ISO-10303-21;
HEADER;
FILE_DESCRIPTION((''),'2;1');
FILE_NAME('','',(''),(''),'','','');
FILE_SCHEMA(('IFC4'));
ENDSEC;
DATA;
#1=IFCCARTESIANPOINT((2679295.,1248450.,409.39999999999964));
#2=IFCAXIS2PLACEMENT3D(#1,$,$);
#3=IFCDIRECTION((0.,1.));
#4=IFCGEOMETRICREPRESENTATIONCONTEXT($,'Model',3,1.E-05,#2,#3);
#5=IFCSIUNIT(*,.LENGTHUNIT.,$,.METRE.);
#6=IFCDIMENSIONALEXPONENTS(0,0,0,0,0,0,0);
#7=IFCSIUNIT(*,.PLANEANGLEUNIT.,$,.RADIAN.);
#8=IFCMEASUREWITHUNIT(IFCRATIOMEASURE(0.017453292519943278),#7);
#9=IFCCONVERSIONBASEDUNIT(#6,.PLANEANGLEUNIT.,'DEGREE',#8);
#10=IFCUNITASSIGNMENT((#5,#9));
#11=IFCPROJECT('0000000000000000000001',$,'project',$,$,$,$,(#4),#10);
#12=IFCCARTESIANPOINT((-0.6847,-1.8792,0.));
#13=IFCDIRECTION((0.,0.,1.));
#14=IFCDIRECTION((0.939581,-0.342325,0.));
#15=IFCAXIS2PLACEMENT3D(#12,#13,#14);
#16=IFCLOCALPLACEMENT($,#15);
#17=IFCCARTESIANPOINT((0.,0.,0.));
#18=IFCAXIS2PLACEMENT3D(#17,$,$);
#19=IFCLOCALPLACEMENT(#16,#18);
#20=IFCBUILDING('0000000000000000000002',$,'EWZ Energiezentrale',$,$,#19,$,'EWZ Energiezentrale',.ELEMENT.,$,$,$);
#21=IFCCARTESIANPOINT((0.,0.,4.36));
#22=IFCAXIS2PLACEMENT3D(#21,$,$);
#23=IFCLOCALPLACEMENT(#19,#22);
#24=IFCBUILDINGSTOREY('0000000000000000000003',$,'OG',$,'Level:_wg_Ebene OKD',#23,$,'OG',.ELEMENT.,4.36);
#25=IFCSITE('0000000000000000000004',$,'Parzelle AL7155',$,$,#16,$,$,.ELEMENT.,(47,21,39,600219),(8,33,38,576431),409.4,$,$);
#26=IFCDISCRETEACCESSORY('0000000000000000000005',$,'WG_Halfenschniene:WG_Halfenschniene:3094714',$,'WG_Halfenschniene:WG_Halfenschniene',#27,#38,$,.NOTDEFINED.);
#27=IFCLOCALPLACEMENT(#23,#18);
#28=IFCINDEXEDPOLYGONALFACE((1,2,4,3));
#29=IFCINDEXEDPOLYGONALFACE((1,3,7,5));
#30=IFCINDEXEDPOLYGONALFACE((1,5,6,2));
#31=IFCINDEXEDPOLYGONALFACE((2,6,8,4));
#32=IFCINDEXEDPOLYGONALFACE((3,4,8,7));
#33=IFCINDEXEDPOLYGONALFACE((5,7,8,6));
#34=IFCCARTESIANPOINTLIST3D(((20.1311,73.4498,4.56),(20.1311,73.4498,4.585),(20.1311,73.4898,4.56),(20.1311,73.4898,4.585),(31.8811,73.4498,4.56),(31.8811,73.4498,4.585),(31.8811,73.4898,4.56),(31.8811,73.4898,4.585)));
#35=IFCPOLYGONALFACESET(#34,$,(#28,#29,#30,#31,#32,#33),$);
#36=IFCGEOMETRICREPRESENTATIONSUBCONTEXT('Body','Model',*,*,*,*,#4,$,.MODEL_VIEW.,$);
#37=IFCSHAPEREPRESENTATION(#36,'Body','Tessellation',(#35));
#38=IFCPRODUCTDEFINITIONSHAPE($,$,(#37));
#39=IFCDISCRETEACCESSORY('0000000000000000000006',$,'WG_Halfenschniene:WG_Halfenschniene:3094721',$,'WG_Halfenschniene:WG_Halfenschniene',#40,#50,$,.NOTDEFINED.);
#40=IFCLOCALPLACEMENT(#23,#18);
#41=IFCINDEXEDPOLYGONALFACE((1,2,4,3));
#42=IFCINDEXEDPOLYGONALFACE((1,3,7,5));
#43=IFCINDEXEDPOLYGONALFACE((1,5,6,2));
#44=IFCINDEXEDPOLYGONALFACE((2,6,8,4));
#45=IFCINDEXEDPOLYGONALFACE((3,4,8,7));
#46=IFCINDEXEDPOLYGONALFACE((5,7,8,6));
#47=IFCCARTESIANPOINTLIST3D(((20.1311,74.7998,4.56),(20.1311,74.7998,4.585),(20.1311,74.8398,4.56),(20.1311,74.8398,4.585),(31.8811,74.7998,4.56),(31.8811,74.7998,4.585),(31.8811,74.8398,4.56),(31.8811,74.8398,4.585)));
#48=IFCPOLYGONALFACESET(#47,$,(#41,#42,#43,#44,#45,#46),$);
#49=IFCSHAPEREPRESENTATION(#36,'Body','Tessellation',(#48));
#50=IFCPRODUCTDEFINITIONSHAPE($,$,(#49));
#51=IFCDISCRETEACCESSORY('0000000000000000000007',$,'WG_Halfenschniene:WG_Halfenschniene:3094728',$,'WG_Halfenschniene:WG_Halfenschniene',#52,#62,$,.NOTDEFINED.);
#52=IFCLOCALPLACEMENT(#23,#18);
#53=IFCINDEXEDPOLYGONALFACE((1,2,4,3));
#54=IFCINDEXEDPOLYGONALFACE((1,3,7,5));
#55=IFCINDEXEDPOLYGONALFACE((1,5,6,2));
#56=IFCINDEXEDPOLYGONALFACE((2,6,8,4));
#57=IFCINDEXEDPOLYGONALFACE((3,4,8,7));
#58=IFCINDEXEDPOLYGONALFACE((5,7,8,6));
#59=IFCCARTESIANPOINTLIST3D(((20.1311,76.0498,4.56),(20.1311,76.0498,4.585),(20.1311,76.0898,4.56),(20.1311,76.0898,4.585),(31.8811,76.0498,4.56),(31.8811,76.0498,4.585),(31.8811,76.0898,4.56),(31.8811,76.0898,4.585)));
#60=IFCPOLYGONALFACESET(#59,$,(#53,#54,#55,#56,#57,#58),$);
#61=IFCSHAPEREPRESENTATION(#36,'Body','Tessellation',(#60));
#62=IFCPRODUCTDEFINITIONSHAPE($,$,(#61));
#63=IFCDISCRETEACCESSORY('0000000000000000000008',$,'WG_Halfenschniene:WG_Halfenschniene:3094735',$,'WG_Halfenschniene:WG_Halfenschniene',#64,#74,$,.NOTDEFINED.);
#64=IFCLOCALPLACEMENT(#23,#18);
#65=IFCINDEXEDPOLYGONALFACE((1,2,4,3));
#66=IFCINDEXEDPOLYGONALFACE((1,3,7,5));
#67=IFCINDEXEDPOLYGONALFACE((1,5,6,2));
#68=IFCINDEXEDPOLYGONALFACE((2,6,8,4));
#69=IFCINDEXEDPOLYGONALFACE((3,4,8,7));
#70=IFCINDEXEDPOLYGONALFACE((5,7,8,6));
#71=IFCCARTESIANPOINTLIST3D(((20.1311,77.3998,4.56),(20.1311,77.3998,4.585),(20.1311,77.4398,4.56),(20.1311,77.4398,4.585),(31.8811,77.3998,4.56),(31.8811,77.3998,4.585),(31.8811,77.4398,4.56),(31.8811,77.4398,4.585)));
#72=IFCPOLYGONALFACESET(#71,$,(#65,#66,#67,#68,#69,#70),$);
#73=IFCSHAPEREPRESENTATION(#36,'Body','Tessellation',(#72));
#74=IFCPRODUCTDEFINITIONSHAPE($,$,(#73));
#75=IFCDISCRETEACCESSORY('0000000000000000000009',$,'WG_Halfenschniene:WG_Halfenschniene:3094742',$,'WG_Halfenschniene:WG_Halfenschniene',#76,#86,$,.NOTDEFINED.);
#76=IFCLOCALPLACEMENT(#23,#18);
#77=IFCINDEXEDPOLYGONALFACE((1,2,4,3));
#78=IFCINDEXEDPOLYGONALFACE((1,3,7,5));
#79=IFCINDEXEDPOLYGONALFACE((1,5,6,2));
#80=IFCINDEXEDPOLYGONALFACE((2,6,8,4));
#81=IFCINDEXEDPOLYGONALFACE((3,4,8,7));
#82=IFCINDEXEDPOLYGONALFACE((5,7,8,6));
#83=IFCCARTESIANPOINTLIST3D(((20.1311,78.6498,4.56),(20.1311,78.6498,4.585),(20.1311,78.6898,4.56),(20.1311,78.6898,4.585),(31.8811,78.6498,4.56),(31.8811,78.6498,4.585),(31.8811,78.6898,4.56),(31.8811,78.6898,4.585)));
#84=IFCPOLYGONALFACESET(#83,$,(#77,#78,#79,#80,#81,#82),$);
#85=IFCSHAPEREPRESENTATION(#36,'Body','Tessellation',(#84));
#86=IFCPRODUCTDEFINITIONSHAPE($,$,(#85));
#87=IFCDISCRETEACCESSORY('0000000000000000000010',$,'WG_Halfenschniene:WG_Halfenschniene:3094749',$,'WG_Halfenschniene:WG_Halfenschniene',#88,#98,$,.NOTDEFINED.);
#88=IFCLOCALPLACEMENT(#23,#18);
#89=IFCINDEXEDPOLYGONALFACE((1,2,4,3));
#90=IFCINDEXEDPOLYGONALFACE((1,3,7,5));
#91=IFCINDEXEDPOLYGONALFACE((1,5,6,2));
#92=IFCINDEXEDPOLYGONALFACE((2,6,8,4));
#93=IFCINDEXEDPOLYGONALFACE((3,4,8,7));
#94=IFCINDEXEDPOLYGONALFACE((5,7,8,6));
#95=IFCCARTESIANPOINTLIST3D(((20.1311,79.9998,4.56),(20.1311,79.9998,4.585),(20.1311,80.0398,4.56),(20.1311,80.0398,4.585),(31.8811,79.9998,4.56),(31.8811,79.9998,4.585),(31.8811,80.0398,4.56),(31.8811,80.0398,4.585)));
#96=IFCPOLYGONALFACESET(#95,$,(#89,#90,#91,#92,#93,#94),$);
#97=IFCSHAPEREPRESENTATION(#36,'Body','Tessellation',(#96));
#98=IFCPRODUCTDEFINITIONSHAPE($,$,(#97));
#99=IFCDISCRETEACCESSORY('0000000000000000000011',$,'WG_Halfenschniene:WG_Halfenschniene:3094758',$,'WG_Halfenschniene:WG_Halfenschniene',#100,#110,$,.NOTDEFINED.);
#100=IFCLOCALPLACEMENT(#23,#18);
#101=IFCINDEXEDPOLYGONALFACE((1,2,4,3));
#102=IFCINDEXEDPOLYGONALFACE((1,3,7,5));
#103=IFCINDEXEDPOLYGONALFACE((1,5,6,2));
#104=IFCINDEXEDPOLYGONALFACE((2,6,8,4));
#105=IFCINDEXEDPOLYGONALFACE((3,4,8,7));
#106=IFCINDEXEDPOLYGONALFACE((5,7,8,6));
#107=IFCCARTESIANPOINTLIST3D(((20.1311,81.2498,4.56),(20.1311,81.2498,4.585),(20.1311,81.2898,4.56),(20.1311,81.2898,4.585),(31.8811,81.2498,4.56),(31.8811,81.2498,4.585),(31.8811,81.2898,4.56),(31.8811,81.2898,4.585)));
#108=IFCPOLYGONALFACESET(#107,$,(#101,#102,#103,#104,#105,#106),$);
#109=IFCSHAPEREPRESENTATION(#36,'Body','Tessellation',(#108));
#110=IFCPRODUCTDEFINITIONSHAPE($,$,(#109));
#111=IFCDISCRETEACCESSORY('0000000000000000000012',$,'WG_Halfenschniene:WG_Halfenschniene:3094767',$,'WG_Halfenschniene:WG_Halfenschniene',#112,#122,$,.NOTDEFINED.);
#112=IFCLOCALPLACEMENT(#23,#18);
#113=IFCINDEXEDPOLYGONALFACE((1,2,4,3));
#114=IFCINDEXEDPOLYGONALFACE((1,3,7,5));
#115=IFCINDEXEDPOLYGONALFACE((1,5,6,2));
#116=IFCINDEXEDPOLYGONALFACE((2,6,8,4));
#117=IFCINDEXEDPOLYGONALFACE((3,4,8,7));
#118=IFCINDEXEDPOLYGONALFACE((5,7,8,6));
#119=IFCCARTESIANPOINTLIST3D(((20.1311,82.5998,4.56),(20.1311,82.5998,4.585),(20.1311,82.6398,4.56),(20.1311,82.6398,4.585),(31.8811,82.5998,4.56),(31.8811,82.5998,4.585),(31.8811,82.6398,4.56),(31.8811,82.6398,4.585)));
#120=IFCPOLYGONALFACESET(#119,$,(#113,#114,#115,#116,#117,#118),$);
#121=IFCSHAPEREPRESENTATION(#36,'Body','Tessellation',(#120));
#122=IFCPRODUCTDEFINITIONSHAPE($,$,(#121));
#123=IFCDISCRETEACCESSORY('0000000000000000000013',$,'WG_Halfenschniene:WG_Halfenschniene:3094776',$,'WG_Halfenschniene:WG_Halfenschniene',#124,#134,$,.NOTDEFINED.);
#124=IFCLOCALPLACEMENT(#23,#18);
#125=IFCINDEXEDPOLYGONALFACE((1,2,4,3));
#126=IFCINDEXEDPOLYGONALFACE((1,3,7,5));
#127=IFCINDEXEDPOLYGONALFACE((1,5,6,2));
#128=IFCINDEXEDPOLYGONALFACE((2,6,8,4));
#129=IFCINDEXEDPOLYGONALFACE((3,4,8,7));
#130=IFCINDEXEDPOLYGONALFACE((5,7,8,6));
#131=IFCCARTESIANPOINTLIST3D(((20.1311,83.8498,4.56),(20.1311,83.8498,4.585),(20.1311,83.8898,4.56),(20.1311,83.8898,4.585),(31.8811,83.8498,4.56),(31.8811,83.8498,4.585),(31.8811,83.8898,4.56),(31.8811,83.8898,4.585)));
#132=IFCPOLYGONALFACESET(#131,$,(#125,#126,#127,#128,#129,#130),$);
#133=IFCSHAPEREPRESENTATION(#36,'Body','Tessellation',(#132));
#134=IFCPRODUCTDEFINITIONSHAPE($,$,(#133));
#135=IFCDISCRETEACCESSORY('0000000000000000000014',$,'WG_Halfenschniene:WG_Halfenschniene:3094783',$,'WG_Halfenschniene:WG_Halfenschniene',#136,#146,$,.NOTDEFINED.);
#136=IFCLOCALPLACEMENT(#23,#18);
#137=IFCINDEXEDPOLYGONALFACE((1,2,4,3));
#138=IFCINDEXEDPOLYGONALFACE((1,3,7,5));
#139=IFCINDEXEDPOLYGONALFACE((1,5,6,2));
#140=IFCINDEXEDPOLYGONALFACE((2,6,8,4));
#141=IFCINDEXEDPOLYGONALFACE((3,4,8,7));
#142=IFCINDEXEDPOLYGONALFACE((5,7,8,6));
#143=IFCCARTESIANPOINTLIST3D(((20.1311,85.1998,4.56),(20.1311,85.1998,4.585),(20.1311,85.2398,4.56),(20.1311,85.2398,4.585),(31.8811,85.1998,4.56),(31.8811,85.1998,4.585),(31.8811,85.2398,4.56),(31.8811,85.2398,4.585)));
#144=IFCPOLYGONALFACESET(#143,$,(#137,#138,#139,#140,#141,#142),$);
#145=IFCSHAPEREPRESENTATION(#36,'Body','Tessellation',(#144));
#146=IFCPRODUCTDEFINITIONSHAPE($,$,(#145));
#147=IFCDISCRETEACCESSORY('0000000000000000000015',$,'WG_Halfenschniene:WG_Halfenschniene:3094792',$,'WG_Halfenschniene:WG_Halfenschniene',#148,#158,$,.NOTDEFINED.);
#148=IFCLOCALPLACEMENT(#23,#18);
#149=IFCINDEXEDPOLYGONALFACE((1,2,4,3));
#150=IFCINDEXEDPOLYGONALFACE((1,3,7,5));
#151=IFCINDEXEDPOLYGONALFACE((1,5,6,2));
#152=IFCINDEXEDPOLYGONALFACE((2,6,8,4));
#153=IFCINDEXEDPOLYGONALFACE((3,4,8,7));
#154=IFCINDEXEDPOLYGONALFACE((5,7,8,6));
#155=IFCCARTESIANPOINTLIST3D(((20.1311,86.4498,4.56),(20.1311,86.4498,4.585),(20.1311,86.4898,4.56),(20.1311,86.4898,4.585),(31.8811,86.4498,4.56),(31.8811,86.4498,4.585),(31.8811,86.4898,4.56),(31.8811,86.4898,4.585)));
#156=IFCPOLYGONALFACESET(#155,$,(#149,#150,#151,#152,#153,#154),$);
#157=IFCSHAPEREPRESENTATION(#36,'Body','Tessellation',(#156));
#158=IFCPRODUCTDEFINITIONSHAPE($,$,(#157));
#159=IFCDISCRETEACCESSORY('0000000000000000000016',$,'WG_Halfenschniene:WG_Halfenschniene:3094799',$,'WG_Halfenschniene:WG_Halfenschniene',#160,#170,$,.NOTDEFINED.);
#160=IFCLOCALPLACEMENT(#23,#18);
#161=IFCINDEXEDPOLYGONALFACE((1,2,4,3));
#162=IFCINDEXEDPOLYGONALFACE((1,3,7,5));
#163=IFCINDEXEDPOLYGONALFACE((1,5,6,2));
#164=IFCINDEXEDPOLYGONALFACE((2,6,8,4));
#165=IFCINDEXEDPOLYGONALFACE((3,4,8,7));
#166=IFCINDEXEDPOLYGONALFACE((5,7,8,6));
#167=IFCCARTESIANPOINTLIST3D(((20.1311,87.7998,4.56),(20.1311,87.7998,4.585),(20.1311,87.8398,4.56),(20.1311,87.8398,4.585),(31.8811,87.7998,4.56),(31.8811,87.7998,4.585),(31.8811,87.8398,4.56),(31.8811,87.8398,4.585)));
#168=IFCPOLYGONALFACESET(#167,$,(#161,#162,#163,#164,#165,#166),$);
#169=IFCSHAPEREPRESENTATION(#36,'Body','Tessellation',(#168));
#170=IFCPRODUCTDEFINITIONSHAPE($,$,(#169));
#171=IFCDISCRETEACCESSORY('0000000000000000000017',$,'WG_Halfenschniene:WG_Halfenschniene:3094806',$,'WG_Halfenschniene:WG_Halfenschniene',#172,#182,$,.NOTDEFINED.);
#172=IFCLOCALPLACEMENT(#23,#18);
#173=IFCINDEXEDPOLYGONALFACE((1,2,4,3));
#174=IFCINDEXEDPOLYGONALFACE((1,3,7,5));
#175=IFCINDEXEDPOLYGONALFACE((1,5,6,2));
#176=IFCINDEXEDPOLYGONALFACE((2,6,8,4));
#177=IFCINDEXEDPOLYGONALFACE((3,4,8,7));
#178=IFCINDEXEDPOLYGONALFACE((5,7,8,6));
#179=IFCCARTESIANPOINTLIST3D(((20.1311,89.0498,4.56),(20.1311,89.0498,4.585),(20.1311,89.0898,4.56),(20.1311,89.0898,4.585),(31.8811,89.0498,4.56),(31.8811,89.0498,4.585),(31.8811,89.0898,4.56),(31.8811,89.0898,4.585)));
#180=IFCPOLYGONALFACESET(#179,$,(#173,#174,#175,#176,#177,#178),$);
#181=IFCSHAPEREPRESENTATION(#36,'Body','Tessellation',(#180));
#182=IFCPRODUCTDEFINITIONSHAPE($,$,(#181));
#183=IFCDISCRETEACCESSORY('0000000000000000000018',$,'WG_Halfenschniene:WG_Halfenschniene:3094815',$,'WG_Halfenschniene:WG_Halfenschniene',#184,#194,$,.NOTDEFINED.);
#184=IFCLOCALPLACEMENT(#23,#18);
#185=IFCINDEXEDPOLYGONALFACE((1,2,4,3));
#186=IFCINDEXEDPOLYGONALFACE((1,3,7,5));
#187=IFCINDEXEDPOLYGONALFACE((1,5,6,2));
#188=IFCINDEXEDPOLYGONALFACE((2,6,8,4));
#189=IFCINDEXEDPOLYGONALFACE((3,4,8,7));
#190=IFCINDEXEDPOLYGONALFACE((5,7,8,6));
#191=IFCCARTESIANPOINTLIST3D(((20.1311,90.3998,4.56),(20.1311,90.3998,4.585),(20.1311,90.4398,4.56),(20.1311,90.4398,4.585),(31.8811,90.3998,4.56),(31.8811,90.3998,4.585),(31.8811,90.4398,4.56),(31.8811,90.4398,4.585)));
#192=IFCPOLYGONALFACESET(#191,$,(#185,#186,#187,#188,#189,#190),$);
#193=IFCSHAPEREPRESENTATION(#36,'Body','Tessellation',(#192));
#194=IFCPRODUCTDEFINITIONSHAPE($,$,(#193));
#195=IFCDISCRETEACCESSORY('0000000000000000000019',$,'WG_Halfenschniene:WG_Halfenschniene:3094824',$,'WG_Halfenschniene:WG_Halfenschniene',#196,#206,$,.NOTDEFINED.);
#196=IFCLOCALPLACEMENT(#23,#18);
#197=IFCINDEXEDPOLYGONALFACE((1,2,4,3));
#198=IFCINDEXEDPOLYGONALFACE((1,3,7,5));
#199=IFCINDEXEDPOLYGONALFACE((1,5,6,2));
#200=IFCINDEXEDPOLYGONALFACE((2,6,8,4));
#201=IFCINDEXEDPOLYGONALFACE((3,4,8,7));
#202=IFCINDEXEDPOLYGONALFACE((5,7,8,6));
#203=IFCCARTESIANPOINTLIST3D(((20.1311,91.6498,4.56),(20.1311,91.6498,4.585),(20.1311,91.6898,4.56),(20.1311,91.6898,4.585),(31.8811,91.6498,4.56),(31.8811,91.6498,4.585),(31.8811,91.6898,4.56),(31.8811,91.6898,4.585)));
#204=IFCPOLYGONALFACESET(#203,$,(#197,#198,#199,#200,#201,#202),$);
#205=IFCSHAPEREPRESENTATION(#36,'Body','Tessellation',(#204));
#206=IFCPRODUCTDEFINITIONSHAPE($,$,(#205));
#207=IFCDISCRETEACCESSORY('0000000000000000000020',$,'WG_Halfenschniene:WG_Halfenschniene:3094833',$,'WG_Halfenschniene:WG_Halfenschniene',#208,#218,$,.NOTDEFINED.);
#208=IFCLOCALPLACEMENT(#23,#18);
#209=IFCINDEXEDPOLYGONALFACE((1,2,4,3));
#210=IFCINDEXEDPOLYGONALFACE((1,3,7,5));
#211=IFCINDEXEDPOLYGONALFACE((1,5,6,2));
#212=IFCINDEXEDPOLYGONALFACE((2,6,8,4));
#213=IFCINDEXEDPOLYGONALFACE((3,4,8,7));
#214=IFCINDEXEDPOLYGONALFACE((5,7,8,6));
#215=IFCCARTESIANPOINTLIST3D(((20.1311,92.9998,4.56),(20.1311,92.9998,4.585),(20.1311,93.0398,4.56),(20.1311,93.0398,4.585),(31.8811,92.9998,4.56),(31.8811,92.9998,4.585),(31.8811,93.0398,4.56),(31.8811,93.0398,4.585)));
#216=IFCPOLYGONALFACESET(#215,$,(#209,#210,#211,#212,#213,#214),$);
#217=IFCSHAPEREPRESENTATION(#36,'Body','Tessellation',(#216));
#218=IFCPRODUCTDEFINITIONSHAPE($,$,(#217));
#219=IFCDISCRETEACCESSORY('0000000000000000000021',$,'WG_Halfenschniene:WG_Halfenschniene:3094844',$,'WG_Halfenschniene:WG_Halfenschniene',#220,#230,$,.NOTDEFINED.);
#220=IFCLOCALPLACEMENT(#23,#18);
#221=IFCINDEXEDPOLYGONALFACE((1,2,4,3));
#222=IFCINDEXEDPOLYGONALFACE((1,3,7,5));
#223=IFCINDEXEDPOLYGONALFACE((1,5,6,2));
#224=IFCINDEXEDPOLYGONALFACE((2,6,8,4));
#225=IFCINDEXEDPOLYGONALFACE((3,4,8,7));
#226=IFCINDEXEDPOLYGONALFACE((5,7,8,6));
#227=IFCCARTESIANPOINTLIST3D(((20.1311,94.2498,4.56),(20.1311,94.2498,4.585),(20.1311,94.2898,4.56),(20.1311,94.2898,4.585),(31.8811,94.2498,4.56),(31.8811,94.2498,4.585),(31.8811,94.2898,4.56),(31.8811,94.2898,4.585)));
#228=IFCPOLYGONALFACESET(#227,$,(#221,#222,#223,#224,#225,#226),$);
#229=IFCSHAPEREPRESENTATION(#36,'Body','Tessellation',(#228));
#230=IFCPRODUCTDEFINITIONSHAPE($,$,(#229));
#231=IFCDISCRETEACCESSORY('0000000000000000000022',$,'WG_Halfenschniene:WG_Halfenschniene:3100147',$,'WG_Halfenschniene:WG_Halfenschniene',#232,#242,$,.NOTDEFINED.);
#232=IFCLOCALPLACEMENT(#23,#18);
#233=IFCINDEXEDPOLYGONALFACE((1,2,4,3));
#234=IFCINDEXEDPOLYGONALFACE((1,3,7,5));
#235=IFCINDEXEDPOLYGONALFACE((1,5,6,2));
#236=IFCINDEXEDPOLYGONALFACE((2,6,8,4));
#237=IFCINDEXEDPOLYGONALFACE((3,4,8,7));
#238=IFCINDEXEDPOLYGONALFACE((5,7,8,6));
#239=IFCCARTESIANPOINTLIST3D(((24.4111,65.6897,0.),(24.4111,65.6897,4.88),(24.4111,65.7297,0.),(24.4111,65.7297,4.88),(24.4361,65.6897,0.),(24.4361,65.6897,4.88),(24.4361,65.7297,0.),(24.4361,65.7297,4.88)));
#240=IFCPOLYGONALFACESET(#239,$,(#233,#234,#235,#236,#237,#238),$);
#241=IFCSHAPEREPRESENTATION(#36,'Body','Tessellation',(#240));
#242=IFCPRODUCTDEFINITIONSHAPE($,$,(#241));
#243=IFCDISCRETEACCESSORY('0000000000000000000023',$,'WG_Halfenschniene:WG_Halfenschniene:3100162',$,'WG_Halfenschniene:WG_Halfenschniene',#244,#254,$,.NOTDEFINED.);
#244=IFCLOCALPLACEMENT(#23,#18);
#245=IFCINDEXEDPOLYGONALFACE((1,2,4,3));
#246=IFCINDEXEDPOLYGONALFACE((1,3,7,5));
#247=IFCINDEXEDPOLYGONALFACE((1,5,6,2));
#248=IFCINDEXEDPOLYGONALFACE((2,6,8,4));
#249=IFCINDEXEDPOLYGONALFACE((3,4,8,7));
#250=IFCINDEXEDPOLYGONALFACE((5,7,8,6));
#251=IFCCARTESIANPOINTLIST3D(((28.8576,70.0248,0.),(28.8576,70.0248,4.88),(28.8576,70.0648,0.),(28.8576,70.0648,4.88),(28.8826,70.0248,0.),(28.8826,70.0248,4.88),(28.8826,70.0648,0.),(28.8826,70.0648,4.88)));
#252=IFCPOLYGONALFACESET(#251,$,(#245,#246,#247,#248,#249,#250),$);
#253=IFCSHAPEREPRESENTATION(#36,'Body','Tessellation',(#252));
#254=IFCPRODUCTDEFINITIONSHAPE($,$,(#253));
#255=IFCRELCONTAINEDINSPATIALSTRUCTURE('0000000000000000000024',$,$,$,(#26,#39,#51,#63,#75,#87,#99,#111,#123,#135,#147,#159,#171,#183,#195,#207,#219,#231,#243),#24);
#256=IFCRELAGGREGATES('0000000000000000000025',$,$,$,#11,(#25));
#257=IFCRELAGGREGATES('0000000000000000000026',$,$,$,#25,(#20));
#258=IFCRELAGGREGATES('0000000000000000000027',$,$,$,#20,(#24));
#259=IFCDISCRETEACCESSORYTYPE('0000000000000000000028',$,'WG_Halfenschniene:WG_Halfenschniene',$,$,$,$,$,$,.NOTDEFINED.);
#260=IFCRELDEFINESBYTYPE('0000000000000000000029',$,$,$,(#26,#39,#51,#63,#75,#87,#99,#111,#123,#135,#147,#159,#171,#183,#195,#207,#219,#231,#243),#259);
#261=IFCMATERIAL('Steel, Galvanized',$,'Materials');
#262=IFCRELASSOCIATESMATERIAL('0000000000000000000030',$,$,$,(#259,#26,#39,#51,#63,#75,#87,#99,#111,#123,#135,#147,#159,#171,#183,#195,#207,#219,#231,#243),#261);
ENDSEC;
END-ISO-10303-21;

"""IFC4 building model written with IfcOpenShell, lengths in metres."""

from ifc_helpers import new_model, entity, si_unit, converted_unit, direction, frame, origin, place, context, subcontext, project, spatial, indexed_curve, outline, extrude, source, transform, mapped, material, type_object, type_shapes, element, save


model = new_model("IFC4")

# Units and contexts
model_context = context("Model", 3, precision=1e-05, world=frame((2679295.0, 1248450.0, 409.39999999999964)), true_north=direction((0.0, 1.0)))
body_context = subcontext(model_context, "Body", "Model", "MODEL_VIEW")
ifc_project = project(units=[si_unit("LENGTHUNIT", "METRE"), converted_unit("PLANEANGLEUNIT", "DEGREE", entity("IfcRatioMeasure", 0.017453292519943278), si_unit("PLANEANGLEUNIT", "RADIAN"), dimensions=[0, 0, 0, 0, 0, 0, 0])], contexts=[model_context])

# Site, building, storey
site_placement = place(None, frame((-0.6847, -1.8792, 0.0), z_axis=(0.0, 0.0, 1.0), x_axis=(0.939581, -0.342325, 0.0)))
site = spatial("IfcSite", under=ifc_project, at=site_placement, Name="Parzelle AL7155", CompositionType="ELEMENT", RefLatitude=(47, 21, 39, 600219), RefLongitude=(8, 33, 38, 576431), RefElevation=409.4)
building_placement = place(site_placement, origin())
building = spatial("IfcBuilding", under=site, at=building_placement, Name="EWZ Energiezentrale", LongName="EWZ Energiezentrale", CompositionType="ELEMENT")
storey_placement = place(building_placement, frame((0.0, 0.0, 4.36)))
storey = spatial("IfcBuildingStorey", under=building, at=storey_placement, Name="OG", ObjectType="Level:_wg_Ebene OKD", LongName="OG", CompositionType="ELEMENT", Elevation=4.36)

# Discrete accessories
ifc_material_1 = material(Name="Steel, Galvanized", Category="Materials")
discrete_accessory_type = type_object("IfcDiscreteAccessoryType", Name="WG_Halfenschniene:WG_Halfenschniene", PredefinedType="NOTDEFINED", material=ifc_material_1)
shared_shape_1 = source(origin(), body_context, "Body", "SweptSolid", [
    extrude(outline(indexed_curve([(-5.875, -0.02), (5.875, -0.02), (5.875, 0.02), (-5.875, 0.02), (-5.875, -0.02)], self_intersect=False)), frame((5.875, 0.0, -0.0125)), (0.0, 0.0, 1.0), 0.025),
])
type_shapes(discrete_accessory_type, [shared_shape_1])
for number, where, z_axis, x_axis, name in (
    (1, (20.1311, 73.4698, 4.5725), (0.0, 0.0, -1.0), (1.0, 0.0, 0.0), "WG_Halfenschniene:WG_Halfenschniene:3094714"),
    (2, (20.1311, 74.8198, 4.5725), (0.0, 0.0, -1.0), (1.0, 0.0, 0.0), "WG_Halfenschniene:WG_Halfenschniene:3094721"),
    (3, (20.1311, 76.0698, 4.5725), (0.0, 0.0, -1.0), (1.0, 0.0, 0.0), "WG_Halfenschniene:WG_Halfenschniene:3094728"),
    (4, (20.1311, 77.4198, 4.5725), (0.0, 0.0, -1.0), (1.0, 0.0, 0.0), "WG_Halfenschniene:WG_Halfenschniene:3094735"),
    (5, (20.1311, 78.6698, 4.5725), (0.0, 0.0, -1.0), (1.0, 0.0, 0.0), "WG_Halfenschniene:WG_Halfenschniene:3094742"),
    (6, (20.1311, 80.0198, 4.5725), (0.0, 0.0, -1.0), (1.0, 0.0, 0.0), "WG_Halfenschniene:WG_Halfenschniene:3094749"),
    (7, (20.1311, 81.2698, 4.5725), (0.0, 0.0, -1.0), (1.0, 0.0, 0.0), "WG_Halfenschniene:WG_Halfenschniene:3094758"),
    (8, (20.1311, 82.6198, 4.5725), (0.0, 0.0, -1.0), (1.0, 0.0, 0.0), "WG_Halfenschniene:WG_Halfenschniene:3094767"),
    (9, (20.1311, 83.8698, 4.5725), (0.0, 0.0, -1.0), (1.0, 0.0, 0.0), "WG_Halfenschniene:WG_Halfenschniene:3094776"),
    (10, (20.1311, 85.2198, 4.5725), (0.0, 0.0, -1.0), (1.0, 0.0, 0.0), "WG_Halfenschniene:WG_Halfenschniene:3094783"),
    (11, (20.1311, 86.4698, 4.5725), (0.0, 0.0, -1.0), (1.0, 0.0, 0.0), "WG_Halfenschniene:WG_Halfenschniene:3094792"),
    (12, (20.1311, 87.8198, 4.5725), (0.0, 0.0, -1.0), (1.0, 0.0, 0.0), "WG_Halfenschniene:WG_Halfenschniene:3094799"),
    (13, (20.1311, 89.0698, 4.5725), (0.0, 0.0, -1.0), (1.0, 0.0, 0.0), "WG_Halfenschniene:WG_Halfenschniene:3094806"),
    (14, (20.1311, 90.4198, 4.5725), (0.0, 0.0, -1.0), (1.0, 0.0, 0.0), "WG_Halfenschniene:WG_Halfenschniene:3094815"),
    (15, (20.1311, 91.6698, 4.5725), (0.0, 0.0, -1.0), (1.0, 0.0, 0.0), "WG_Halfenschniene:WG_Halfenschniene:3094824"),
    (16, (20.1311, 93.0198, 4.5725), (0.0, 0.0, -1.0), (1.0, 0.0, 0.0), "WG_Halfenschniene:WG_Halfenschniene:3094833"),
    (17, (20.1311, 94.2698, 4.5725), (0.0, 0.0, -1.0), (1.0, 0.0, 0.0), "WG_Halfenschniene:WG_Halfenschniene:3094844"),
):
    element("IfcDiscreteAccessory", number, at=place(storey_placement, frame(where, z_axis=z_axis, x_axis=x_axis)), inside=storey, type_object=discrete_accessory_type, material=ifc_material_1, Name=name, ObjectType="WG_Halfenschniene:WG_Halfenschniene", PredefinedType="NOTDEFINED", context=body_context, shape_type="MappedRepresentation", body=[
        mapped(shared_shape_1, transform((0.0, 0.0, 0.0), scale=1.0)),
    ])
shared_shape_2 = source(origin(), body_context, "Body", "SweptSolid", [
    extrude(outline(indexed_curve([(-2.44, -0.02), (2.44, -0.02), (2.44, 0.02), (-2.44, 0.02), (-2.44, -0.02)], self_intersect=False)), frame((2.44, 0.0, -0.0125)), (0.0, 0.0, 1.0), 0.025),
])
for number, where, z_axis, x_axis, name in (
    (18, (24.4236, 65.7097, 0.0), (-1.0, 0.0, 0.0), (0.0, 0.0, 1.0), "WG_Halfenschniene:WG_Halfenschniene:3100147"),
    (19, (28.8701, 70.0448, 4.88), (1.0, 0.0, 0.0), (0.0, 0.0, -1.0), "WG_Halfenschniene:WG_Halfenschniene:3100162"),
):
    element("IfcDiscreteAccessory", number, at=place(storey_placement, frame(where, z_axis=z_axis, x_axis=x_axis)), inside=storey, type_object=discrete_accessory_type, material=ifc_material_1, Name=name, ObjectType="WG_Halfenschniene:WG_Halfenschniene", PredefinedType="NOTDEFINED", context=body_context, shape_type="MappedRepresentation", body=[
        mapped(shared_shape_2, transform((0.0, 0.0, 0.0), scale=1.0)),
    ])

save(model, "model.ifc")
